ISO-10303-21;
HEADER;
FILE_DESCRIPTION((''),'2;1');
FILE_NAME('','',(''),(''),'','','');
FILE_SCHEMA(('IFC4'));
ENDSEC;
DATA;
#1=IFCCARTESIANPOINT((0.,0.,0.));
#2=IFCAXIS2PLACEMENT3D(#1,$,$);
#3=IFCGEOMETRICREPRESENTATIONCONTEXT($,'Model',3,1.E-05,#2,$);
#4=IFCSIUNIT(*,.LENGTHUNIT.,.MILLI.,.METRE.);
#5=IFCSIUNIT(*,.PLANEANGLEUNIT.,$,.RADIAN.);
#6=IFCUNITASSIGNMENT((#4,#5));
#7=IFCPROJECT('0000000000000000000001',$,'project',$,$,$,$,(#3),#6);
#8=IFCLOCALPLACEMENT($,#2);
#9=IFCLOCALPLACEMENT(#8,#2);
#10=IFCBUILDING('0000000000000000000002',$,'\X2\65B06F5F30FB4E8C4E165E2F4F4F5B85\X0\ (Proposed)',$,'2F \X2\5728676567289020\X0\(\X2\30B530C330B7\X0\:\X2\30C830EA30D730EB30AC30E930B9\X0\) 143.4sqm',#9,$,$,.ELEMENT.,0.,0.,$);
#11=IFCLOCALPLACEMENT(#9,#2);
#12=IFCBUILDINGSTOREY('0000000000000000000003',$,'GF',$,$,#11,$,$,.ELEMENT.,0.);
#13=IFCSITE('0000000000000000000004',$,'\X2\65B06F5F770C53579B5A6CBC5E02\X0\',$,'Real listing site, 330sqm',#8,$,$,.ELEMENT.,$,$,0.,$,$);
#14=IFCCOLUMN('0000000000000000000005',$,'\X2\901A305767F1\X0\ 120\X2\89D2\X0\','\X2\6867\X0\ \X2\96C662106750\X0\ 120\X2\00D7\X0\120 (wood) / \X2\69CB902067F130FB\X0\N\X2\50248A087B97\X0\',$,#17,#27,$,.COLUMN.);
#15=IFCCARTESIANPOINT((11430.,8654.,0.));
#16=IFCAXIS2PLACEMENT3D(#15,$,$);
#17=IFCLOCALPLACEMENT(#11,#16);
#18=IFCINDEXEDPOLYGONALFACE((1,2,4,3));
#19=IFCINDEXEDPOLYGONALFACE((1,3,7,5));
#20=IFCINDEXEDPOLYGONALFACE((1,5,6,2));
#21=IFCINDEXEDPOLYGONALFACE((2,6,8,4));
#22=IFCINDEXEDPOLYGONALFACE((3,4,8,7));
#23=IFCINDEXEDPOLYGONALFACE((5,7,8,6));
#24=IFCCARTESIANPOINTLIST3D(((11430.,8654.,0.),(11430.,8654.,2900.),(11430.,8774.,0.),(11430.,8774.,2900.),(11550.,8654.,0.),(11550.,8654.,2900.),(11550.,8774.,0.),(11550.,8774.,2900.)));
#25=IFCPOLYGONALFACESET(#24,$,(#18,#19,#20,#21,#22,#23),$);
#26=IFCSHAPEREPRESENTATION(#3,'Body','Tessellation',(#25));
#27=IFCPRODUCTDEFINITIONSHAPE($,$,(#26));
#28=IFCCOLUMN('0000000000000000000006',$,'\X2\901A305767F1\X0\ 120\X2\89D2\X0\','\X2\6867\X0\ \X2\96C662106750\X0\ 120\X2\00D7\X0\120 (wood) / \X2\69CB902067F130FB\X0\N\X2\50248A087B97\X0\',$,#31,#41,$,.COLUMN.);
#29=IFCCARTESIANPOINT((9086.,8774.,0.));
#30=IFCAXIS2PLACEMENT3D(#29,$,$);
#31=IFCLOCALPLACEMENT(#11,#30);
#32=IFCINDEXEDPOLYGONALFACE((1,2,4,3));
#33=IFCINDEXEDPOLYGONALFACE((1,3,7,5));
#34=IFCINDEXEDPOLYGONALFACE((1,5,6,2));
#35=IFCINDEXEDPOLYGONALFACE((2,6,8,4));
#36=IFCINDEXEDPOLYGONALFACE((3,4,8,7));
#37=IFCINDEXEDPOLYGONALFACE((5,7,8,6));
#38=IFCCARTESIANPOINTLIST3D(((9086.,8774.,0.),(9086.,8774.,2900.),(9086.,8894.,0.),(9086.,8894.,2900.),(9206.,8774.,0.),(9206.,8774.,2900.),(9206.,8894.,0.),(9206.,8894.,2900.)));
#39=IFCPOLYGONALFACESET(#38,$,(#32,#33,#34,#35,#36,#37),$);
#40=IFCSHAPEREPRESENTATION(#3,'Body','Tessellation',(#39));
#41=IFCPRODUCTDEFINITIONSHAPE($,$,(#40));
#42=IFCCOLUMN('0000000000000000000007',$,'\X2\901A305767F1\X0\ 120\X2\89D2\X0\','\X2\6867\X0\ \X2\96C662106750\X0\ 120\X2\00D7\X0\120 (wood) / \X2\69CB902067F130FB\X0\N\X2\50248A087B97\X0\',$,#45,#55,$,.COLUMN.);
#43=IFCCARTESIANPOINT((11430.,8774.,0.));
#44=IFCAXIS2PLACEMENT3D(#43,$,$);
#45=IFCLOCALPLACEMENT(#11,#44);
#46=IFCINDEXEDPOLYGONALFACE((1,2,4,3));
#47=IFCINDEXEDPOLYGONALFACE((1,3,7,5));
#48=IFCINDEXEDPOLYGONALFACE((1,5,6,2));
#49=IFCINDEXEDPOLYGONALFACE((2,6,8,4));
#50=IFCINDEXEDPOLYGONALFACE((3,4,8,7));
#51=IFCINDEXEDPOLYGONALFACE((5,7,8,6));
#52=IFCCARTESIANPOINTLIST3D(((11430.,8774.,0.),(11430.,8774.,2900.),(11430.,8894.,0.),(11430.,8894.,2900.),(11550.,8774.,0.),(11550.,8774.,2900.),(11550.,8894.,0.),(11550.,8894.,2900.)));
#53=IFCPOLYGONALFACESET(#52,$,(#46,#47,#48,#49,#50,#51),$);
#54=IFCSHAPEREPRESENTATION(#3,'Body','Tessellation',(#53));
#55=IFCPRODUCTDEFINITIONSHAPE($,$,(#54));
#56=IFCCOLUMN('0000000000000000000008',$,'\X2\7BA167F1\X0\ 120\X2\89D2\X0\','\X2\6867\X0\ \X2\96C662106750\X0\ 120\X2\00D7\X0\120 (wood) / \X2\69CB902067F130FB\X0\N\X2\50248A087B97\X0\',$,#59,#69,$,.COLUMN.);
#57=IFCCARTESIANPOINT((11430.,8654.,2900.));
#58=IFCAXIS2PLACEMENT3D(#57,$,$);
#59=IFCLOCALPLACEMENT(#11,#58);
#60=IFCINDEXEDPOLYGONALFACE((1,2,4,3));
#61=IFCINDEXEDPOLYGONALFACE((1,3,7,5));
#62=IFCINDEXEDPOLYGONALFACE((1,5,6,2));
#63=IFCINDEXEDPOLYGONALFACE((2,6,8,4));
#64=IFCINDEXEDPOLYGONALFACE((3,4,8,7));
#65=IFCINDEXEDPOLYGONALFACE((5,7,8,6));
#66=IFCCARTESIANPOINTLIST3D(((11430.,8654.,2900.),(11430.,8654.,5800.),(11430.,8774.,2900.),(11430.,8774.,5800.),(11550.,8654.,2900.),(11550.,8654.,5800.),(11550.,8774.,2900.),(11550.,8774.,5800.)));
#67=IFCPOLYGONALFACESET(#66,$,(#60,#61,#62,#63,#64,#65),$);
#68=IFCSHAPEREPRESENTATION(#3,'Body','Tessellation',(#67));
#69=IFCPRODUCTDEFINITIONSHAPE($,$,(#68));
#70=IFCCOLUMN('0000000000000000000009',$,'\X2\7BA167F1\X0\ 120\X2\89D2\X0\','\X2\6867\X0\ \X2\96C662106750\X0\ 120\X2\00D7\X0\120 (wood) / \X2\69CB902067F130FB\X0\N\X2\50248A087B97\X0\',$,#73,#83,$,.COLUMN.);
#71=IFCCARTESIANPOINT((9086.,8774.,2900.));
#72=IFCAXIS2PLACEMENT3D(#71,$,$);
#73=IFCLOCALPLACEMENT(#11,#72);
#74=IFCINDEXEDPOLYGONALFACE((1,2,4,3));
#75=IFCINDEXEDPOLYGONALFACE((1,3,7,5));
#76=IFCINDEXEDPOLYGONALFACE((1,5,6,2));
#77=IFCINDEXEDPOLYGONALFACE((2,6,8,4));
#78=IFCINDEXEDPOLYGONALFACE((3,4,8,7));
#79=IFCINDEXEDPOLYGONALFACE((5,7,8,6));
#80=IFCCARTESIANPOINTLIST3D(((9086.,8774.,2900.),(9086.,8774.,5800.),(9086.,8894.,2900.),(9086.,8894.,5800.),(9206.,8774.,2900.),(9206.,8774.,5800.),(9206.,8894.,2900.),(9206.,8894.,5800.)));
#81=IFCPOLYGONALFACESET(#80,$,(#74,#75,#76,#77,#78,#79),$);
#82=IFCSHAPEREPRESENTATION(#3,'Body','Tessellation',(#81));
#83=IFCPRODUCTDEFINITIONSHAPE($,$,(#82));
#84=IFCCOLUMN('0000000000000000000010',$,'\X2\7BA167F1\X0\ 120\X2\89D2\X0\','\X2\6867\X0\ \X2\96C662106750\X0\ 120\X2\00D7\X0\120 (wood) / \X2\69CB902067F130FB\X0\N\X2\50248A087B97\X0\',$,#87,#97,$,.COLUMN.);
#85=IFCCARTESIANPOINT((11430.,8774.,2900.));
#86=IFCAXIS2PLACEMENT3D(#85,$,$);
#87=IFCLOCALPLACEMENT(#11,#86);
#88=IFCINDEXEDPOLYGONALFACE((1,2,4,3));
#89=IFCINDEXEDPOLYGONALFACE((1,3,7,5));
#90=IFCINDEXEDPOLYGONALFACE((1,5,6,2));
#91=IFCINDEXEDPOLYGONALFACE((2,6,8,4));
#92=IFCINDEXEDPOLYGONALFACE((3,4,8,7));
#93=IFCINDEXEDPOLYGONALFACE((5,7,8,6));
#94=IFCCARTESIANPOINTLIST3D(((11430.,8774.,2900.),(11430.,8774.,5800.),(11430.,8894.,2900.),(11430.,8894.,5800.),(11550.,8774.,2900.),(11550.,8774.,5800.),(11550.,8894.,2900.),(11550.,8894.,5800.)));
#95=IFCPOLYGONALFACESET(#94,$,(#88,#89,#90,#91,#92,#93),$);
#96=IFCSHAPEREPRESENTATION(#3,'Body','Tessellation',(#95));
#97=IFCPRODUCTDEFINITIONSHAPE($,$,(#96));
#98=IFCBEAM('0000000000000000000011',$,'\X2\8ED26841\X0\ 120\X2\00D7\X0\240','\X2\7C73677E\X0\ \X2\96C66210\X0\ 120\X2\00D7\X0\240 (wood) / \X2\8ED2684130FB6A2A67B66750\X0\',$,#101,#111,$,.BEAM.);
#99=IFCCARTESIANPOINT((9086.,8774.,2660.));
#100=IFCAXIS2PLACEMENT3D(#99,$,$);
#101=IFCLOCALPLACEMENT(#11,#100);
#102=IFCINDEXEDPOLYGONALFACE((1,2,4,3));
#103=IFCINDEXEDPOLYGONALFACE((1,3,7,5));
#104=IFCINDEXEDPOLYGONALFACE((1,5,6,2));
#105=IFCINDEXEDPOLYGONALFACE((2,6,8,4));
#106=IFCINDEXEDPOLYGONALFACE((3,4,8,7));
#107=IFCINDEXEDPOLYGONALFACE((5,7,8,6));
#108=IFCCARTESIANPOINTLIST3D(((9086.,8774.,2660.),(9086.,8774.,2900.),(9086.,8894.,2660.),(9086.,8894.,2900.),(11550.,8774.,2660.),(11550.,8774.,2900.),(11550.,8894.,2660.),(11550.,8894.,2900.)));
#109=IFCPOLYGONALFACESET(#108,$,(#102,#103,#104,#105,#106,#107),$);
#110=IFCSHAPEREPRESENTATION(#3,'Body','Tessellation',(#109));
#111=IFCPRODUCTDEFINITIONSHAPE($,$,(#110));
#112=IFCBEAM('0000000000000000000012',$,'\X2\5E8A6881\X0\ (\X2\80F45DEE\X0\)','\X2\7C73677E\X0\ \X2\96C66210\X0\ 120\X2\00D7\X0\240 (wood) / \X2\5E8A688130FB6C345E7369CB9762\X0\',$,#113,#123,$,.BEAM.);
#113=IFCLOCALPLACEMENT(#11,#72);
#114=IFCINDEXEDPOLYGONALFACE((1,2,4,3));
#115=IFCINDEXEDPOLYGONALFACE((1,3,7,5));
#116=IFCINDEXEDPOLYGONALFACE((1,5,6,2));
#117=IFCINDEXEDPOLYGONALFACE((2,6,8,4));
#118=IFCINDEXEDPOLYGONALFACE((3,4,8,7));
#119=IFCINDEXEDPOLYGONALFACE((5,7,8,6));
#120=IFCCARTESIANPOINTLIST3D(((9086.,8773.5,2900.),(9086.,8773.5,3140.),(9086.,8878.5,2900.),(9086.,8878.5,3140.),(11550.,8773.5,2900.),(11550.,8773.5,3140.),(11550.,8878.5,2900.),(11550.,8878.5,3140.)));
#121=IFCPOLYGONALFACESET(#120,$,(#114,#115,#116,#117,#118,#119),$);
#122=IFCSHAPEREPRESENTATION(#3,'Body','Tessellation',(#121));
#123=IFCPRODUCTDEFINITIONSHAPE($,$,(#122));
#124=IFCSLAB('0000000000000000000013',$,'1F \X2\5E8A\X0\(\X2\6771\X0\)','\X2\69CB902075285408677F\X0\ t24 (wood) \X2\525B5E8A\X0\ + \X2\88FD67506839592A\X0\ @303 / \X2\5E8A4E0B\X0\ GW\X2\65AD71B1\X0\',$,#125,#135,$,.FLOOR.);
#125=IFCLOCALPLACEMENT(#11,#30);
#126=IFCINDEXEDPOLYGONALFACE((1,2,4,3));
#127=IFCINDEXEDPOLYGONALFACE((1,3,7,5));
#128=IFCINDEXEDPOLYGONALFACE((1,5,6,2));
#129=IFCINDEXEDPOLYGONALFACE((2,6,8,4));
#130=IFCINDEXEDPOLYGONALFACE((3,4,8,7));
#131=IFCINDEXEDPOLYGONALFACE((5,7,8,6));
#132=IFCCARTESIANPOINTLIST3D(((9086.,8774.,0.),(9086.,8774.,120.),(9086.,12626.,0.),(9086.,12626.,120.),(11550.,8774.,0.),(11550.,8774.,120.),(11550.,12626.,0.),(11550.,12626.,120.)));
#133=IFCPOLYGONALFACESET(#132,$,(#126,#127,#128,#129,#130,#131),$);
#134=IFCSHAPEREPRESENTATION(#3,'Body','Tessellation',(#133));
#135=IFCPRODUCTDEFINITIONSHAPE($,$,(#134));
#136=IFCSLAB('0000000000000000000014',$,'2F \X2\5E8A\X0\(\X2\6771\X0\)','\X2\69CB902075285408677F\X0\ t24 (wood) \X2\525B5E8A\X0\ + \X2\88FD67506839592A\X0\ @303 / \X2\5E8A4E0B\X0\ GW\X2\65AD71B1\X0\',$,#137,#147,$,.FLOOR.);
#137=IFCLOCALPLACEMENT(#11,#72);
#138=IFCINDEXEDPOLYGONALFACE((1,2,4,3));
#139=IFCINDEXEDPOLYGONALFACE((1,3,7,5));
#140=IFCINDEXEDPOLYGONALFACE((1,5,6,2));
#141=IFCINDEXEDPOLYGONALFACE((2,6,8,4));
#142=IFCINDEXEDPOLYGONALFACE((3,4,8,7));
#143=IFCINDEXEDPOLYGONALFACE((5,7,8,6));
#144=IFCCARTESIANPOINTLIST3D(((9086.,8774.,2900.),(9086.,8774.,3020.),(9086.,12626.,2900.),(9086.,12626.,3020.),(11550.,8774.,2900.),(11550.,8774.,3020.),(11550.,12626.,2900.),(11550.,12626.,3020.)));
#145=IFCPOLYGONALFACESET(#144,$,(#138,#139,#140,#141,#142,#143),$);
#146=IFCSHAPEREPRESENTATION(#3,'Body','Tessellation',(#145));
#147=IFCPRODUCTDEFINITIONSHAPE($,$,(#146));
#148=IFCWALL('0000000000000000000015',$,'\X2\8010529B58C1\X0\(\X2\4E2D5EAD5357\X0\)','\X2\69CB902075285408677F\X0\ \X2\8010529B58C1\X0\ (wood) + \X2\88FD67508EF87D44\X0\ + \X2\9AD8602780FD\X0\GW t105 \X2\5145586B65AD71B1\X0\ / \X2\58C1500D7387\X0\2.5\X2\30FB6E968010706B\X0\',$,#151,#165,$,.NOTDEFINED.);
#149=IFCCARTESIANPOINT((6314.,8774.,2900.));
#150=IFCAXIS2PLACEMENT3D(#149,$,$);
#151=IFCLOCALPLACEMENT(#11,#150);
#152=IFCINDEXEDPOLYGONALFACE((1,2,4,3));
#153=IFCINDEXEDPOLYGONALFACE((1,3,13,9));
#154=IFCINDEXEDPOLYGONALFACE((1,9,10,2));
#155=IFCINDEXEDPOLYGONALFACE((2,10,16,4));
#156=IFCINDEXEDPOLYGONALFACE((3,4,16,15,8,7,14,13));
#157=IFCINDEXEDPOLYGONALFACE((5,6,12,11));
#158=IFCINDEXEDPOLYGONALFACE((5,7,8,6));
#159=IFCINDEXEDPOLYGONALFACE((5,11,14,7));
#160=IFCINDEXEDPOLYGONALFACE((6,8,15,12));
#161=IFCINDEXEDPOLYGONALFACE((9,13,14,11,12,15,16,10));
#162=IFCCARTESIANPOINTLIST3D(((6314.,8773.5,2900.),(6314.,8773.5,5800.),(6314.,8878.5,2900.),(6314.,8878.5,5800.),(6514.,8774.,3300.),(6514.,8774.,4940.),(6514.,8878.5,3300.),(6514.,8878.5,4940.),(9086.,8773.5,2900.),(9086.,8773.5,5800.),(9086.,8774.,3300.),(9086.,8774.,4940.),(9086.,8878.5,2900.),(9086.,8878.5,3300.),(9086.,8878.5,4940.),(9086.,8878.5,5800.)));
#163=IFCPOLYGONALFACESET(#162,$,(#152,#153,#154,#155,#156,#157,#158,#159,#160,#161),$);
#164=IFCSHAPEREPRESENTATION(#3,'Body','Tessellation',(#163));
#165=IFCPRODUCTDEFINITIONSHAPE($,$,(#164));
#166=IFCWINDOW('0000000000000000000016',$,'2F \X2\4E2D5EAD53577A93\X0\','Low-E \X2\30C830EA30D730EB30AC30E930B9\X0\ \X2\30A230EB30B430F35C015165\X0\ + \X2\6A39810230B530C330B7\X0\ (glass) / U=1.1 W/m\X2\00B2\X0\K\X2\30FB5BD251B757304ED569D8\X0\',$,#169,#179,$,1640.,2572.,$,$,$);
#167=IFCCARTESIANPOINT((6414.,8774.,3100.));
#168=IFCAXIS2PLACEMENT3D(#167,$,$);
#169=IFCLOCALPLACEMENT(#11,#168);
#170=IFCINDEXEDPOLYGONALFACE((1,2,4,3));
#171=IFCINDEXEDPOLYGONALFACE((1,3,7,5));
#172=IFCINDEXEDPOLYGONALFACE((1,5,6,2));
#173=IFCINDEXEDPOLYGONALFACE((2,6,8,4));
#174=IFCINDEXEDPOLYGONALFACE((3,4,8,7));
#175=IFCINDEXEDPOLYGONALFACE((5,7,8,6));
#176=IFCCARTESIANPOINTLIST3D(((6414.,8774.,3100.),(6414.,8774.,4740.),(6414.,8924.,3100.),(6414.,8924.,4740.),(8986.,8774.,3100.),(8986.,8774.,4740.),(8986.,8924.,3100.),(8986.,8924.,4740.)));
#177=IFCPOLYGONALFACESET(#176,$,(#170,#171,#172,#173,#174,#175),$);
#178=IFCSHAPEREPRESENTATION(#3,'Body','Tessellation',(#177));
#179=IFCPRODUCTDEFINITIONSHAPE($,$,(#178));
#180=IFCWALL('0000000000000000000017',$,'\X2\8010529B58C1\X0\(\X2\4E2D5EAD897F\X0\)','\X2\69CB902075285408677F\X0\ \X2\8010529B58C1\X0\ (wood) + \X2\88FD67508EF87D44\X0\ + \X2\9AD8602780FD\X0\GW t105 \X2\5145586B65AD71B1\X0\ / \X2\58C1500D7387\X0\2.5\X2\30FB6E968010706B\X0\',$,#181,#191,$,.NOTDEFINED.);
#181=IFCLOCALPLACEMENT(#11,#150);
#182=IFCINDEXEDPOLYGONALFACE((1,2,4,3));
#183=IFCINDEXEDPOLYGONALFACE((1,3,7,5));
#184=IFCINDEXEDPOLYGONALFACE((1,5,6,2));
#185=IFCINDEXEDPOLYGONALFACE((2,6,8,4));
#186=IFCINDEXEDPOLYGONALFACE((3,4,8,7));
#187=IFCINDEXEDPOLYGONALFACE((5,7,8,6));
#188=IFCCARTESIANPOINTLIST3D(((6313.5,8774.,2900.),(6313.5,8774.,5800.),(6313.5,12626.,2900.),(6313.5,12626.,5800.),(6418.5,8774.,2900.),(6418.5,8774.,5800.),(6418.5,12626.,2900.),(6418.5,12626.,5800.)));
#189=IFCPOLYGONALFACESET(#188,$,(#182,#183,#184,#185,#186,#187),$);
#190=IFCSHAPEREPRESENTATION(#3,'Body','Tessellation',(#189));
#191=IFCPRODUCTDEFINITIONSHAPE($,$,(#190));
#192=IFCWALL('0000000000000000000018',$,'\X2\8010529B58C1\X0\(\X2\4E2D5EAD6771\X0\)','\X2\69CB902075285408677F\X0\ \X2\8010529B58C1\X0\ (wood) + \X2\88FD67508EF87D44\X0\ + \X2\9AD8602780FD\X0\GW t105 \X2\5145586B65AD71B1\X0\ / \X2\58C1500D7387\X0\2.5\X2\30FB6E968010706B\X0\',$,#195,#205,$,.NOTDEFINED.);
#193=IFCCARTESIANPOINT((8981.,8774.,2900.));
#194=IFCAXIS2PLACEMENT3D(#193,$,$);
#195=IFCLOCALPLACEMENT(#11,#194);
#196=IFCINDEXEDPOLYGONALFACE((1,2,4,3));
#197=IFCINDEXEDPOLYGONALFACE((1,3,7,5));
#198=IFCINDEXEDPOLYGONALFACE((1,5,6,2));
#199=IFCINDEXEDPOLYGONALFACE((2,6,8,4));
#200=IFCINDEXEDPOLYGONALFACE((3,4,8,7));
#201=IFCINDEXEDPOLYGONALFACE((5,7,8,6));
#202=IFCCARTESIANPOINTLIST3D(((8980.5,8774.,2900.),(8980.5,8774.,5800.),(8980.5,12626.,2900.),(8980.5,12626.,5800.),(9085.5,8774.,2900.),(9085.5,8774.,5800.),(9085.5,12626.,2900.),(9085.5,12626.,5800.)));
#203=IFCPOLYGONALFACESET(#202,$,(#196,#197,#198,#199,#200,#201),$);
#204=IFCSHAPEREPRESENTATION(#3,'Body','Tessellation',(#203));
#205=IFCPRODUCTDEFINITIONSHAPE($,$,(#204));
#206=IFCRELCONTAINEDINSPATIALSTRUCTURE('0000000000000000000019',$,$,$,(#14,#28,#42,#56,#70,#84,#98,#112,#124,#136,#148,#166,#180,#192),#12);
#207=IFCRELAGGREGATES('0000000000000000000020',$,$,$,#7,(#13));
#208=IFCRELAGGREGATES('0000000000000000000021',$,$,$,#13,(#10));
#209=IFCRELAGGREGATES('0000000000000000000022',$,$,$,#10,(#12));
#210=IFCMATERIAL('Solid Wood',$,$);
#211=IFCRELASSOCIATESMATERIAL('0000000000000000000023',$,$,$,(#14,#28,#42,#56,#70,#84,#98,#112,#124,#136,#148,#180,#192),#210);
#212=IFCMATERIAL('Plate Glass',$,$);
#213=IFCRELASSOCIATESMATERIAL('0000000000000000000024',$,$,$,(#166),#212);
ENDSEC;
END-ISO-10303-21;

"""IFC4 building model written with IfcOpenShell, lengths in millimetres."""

from ifc_helpers import new_model, si_unit, frame, frame_2d, origin, place, context, project, spatial, rectangle, extrude, material, element, fill, save


model = new_model("IFC4")

# Units and contexts
model_context = context("Model", 3, precision=1e-05, world=origin())
ifc_project = project(units=[si_unit("LENGTHUNIT", "METRE", prefix="MILLI"), si_unit("PLANEANGLEUNIT", "RADIAN")], contexts=[model_context])

# Site, building, storey
site_placement = place(None, origin())
site = spatial("IfcSite", under=ifc_project, at=site_placement, Name="新潟県南魚沼市", ObjectType="Real listing site, 330sqm", CompositionType="ELEMENT", RefElevation=0.0)
building_placement = place(site_placement, origin())
building = spatial("IfcBuilding", under=site, at=building_placement, Name="新潟・二世帯住宅 (Proposed)", ObjectType="2F 在来木造(サッシ:トリプルガラス) 143.4sqm", CompositionType="ELEMENT", ElevationOfRefHeight=0.0, ElevationOfTerrain=0.0)
storey_placement = place(building_placement, origin())
storey = spatial("IfcBuildingStorey", under=building, at=storey_placement, Name="GF", CompositionType="ELEMENT", Elevation=0.0)

# Columns
ifc_material_1 = material(Name="Solid Wood")
column_1_placement = place(storey_placement, frame((11430.0, 8654.0, 0.0)))
element("IfcColumn", 1, at=column_1_placement, inside=storey, material=ifc_material_1, Name="通し柱 120角", Description="桧 集成材 120×120 (wood) / 構造柱・N値計算", PredefinedType="COLUMN", context=model_context, shape_type="SweptSolid", body=[
    extrude(rectangle(XDim=120.0, YDim=120.0, at=frame_2d((60.0, 60.0))), frame((11430.0, 8654.0, 0.0)), (0.0, 0.0, 1.0), 2900.0),
])
column_2_placement = place(storey_placement, frame((9086.0, 8774.0, 0.0)))
element("IfcColumn", 2, at=column_2_placement, inside=storey, material=ifc_material_1, Name="通し柱 120角", Description="桧 集成材 120×120 (wood) / 構造柱・N値計算", PredefinedType="COLUMN", context=model_context, shape_type="SweptSolid", body=[
    extrude(rectangle(XDim=120.0, YDim=120.0, at=frame_2d((60.0, 60.0))), frame((9086.0, 8774.0, 0.0)), (0.0, 0.0, 1.0), 2900.0),
])
column_3_placement = place(storey_placement, frame((11430.0, 8774.0, 0.0)))
element("IfcColumn", 3, at=column_3_placement, inside=storey, material=ifc_material_1, Name="通し柱 120角", Description="桧 集成材 120×120 (wood) / 構造柱・N値計算", PredefinedType="COLUMN", context=model_context, shape_type="SweptSolid", body=[
    extrude(rectangle(XDim=120.0, YDim=120.0, at=frame_2d((60.0, 60.0))), frame((11430.0, 8774.0, 0.0)), (0.0, 0.0, 1.0), 2900.0),
])
column_4_placement = place(storey_placement, frame((11430.0, 8654.0, 2900.0)))
element("IfcColumn", 4, at=column_4_placement, inside=storey, material=ifc_material_1, Name="管柱 120角", Description="桧 集成材 120×120 (wood) / 構造柱・N値計算", PredefinedType="COLUMN", context=model_context, shape_type="SweptSolid", body=[
    extrude(rectangle(XDim=120.0, YDim=120.0, at=frame_2d((60.0, 60.0))), frame((11430.0, 8654.0, 2900.0)), (0.0, 0.0, 1.0), 2900.0),
])
column_5_placement = place(storey_placement, frame((9086.0, 8774.0, 2900.0)))
element("IfcColumn", 5, at=column_5_placement, inside=storey, material=ifc_material_1, Name="管柱 120角", Description="桧 集成材 120×120 (wood) / 構造柱・N値計算", PredefinedType="COLUMN", context=model_context, shape_type="SweptSolid", body=[
    extrude(rectangle(XDim=120.0, YDim=120.0, at=frame_2d((60.0, 60.0))), frame((9086.0, 8774.0, 2900.0)), (0.0, 0.0, 1.0), 2900.0),
])
column_6_placement = place(storey_placement, frame((11430.0, 8774.0, 2900.0)))
element("IfcColumn", 6, at=column_6_placement, inside=storey, material=ifc_material_1, Name="管柱 120角", Description="桧 集成材 120×120 (wood) / 構造柱・N値計算", PredefinedType="COLUMN", context=model_context, shape_type="SweptSolid", body=[
    extrude(rectangle(XDim=120.0, YDim=120.0, at=frame_2d((60.0, 60.0))), frame((11430.0, 8774.0, 2900.0)), (0.0, 0.0, 1.0), 2900.0),
])

# Beams
beam_1_placement = place(storey_placement, frame((9086.0, 8774.0, 2660.0)))
element("IfcBeam", 7, at=beam_1_placement, inside=storey, material=ifc_material_1, Name="軒桁 120×240", Description="米松 集成 120×240 (wood) / 軒桁・横架材", PredefinedType="BEAM", context=model_context, shape_type="SweptSolid", body=[
    extrude(rectangle(XDim=2464.0, YDim=120.0, at=frame_2d((1232.0, 60.0))), frame((9086.0, 8774.0, 2660.0)), (0.0, 0.0, 1.0), 240.0),
])
beam_2_placement = place(storey_placement, frame((9086.0, 8774.0, 2900.0)))
element("IfcBeam", 8, at=beam_2_placement, inside=storey, material=ifc_material_1, Name="床梁 (胴差)", Description="米松 集成 120×240 (wood) / 床梁・水平構面", PredefinedType="BEAM", context=model_context, shape_type="SweptSolid", body=[
    extrude(rectangle(XDim=2464.0, YDim=105.0, at=frame_2d((1232.0, 52.0))), frame((9086.0, 8774.0, 2900.0)), (0.0, 0.0, 1.0), 240.0),
])

# Slabs
slab_1_placement = place(storey_placement, frame((9086.0, 8774.0, 0.0)))
element("IfcSlab", 9, at=slab_1_placement, inside=storey, material=ifc_material_1, Name="1F 床(東)", Description="構造用合板 t24 (wood) 剛床 + 製材根太 @303 / 床下 GW断熱", PredefinedType="FLOOR", context=model_context, shape_type="SweptSolid", body=[
    extrude(rectangle(XDim=2464.0, YDim=3852.0, at=frame_2d((1232.0, 1926.0))), frame((9086.0, 8774.0, 0.0)), (0.0, 0.0, 1.0), 120.0),
])
slab_2_placement = place(storey_placement, frame((9086.0, 8774.0, 2900.0)))
element("IfcSlab", 10, at=slab_2_placement, inside=storey, material=ifc_material_1, Name="2F 床(東)", Description="構造用合板 t24 (wood) 剛床 + 製材根太 @303 / 床下 GW断熱", PredefinedType="FLOOR", context=model_context, shape_type="SweptSolid", body=[
    extrude(rectangle(XDim=2464.0, YDim=3852.0, at=frame_2d((1232.0, 1926.0))), frame((9086.0, 8774.0, 2900.0)), (0.0, 0.0, 1.0), 120.0),
])

# Wall, opening, window
wall_1_placement = place(storey_placement, frame((6314.0, 8774.0, 2900.0)))
wall_1 = element("IfcWall", 11, at=wall_1_placement, inside=storey, material=ifc_material_1, Name="耐力壁(中庭南)", Description="構造用合板 耐力壁 (wood) + 製材軸組 + 高性能GW t105 充填断熱 / 壁倍率2.5・準耐火", PredefinedType="NOTDEFINED", context=model_context, shape_type="SweptSolid", body=[
    extrude(rectangle(XDim=2772.0, YDim=105.0, at=frame_2d((1386.0, 52.0))), frame((6314.0, 8774.0, 2900.0)), (0.0, 0.0, 1.0), 2900.0),
])
opening_placement = place(storey_placement, frame((6414.0, 8774.0, 3100.0)))
opening = element("IfcOpeningElement", 12, at=opening_placement, cuts=wall_1, PredefinedType="NOTDEFINED", context=model_context, shape_type="SweptSolid", body=[
    extrude(rectangle(XDim=2572.0, YDim=150.0, at=frame_2d((1286.0, 75.0))), frame((6414.0, 8774.0, 3100.0)), (0.0, 0.0, 1.0), 1640.0),
])
ifc_material_2 = material(Name="Plate Glass")
window_placement = place(storey_placement, frame((6414.0, 8774.0, 3100.0)))
window = element("IfcWindow", 13, at=window_placement, inside=storey, material=ifc_material_2, Name="2F 中庭南窓", Description="Low-E トリプルガラス アルゴン封入 + 樹脂サッシ (glass) / U=1.1 W/m²K・寒冷地仕様", OverallHeight=1640.0, OverallWidth=2572.0, context=model_context, shape_type="SweptSolid", body=[
    extrude(rectangle(XDim=2572.0, YDim=150.0, at=frame_2d((1286.0, 75.0))), frame((6414.0, 8774.0, 3100.0)), (0.0, 0.0, 1.0), 1640.0),
])
fill(opening, window)

# Walls
wall_2_placement = place(storey_placement, frame((6314.0, 8774.0, 2900.0)))
element("IfcWall", 14, at=wall_2_placement, inside=storey, material=ifc_material_1, Name="耐力壁(中庭西)", Description="構造用合板 耐力壁 (wood) + 製材軸組 + 高性能GW t105 充填断熱 / 壁倍率2.5・準耐火", PredefinedType="NOTDEFINED", context=model_context, shape_type="SweptSolid", body=[
    extrude(rectangle(XDim=105.0, YDim=3852.0, at=frame_2d((52.0, 1926.0))), frame((6314.0, 8774.0, 2900.0)), (0.0, 0.0, 1.0), 2900.0),
])
wall_3_placement = place(storey_placement, frame((8981.0, 8774.0, 2900.0)))
element("IfcWall", 15, at=wall_3_placement, inside=storey, material=ifc_material_1, Name="耐力壁(中庭東)", Description="構造用合板 耐力壁 (wood) + 製材軸組 + 高性能GW t105 充填断熱 / 壁倍率2.5・準耐火", PredefinedType="NOTDEFINED", context=model_context, shape_type="SweptSolid", body=[
    extrude(rectangle(XDim=105.0, YDim=3852.0, at=frame_2d((52.0, 1926.0))), frame((8981.0, 8774.0, 2900.0)), (0.0, 0.0, 1.0), 2900.0),
])

save(model, "model.ifc")
